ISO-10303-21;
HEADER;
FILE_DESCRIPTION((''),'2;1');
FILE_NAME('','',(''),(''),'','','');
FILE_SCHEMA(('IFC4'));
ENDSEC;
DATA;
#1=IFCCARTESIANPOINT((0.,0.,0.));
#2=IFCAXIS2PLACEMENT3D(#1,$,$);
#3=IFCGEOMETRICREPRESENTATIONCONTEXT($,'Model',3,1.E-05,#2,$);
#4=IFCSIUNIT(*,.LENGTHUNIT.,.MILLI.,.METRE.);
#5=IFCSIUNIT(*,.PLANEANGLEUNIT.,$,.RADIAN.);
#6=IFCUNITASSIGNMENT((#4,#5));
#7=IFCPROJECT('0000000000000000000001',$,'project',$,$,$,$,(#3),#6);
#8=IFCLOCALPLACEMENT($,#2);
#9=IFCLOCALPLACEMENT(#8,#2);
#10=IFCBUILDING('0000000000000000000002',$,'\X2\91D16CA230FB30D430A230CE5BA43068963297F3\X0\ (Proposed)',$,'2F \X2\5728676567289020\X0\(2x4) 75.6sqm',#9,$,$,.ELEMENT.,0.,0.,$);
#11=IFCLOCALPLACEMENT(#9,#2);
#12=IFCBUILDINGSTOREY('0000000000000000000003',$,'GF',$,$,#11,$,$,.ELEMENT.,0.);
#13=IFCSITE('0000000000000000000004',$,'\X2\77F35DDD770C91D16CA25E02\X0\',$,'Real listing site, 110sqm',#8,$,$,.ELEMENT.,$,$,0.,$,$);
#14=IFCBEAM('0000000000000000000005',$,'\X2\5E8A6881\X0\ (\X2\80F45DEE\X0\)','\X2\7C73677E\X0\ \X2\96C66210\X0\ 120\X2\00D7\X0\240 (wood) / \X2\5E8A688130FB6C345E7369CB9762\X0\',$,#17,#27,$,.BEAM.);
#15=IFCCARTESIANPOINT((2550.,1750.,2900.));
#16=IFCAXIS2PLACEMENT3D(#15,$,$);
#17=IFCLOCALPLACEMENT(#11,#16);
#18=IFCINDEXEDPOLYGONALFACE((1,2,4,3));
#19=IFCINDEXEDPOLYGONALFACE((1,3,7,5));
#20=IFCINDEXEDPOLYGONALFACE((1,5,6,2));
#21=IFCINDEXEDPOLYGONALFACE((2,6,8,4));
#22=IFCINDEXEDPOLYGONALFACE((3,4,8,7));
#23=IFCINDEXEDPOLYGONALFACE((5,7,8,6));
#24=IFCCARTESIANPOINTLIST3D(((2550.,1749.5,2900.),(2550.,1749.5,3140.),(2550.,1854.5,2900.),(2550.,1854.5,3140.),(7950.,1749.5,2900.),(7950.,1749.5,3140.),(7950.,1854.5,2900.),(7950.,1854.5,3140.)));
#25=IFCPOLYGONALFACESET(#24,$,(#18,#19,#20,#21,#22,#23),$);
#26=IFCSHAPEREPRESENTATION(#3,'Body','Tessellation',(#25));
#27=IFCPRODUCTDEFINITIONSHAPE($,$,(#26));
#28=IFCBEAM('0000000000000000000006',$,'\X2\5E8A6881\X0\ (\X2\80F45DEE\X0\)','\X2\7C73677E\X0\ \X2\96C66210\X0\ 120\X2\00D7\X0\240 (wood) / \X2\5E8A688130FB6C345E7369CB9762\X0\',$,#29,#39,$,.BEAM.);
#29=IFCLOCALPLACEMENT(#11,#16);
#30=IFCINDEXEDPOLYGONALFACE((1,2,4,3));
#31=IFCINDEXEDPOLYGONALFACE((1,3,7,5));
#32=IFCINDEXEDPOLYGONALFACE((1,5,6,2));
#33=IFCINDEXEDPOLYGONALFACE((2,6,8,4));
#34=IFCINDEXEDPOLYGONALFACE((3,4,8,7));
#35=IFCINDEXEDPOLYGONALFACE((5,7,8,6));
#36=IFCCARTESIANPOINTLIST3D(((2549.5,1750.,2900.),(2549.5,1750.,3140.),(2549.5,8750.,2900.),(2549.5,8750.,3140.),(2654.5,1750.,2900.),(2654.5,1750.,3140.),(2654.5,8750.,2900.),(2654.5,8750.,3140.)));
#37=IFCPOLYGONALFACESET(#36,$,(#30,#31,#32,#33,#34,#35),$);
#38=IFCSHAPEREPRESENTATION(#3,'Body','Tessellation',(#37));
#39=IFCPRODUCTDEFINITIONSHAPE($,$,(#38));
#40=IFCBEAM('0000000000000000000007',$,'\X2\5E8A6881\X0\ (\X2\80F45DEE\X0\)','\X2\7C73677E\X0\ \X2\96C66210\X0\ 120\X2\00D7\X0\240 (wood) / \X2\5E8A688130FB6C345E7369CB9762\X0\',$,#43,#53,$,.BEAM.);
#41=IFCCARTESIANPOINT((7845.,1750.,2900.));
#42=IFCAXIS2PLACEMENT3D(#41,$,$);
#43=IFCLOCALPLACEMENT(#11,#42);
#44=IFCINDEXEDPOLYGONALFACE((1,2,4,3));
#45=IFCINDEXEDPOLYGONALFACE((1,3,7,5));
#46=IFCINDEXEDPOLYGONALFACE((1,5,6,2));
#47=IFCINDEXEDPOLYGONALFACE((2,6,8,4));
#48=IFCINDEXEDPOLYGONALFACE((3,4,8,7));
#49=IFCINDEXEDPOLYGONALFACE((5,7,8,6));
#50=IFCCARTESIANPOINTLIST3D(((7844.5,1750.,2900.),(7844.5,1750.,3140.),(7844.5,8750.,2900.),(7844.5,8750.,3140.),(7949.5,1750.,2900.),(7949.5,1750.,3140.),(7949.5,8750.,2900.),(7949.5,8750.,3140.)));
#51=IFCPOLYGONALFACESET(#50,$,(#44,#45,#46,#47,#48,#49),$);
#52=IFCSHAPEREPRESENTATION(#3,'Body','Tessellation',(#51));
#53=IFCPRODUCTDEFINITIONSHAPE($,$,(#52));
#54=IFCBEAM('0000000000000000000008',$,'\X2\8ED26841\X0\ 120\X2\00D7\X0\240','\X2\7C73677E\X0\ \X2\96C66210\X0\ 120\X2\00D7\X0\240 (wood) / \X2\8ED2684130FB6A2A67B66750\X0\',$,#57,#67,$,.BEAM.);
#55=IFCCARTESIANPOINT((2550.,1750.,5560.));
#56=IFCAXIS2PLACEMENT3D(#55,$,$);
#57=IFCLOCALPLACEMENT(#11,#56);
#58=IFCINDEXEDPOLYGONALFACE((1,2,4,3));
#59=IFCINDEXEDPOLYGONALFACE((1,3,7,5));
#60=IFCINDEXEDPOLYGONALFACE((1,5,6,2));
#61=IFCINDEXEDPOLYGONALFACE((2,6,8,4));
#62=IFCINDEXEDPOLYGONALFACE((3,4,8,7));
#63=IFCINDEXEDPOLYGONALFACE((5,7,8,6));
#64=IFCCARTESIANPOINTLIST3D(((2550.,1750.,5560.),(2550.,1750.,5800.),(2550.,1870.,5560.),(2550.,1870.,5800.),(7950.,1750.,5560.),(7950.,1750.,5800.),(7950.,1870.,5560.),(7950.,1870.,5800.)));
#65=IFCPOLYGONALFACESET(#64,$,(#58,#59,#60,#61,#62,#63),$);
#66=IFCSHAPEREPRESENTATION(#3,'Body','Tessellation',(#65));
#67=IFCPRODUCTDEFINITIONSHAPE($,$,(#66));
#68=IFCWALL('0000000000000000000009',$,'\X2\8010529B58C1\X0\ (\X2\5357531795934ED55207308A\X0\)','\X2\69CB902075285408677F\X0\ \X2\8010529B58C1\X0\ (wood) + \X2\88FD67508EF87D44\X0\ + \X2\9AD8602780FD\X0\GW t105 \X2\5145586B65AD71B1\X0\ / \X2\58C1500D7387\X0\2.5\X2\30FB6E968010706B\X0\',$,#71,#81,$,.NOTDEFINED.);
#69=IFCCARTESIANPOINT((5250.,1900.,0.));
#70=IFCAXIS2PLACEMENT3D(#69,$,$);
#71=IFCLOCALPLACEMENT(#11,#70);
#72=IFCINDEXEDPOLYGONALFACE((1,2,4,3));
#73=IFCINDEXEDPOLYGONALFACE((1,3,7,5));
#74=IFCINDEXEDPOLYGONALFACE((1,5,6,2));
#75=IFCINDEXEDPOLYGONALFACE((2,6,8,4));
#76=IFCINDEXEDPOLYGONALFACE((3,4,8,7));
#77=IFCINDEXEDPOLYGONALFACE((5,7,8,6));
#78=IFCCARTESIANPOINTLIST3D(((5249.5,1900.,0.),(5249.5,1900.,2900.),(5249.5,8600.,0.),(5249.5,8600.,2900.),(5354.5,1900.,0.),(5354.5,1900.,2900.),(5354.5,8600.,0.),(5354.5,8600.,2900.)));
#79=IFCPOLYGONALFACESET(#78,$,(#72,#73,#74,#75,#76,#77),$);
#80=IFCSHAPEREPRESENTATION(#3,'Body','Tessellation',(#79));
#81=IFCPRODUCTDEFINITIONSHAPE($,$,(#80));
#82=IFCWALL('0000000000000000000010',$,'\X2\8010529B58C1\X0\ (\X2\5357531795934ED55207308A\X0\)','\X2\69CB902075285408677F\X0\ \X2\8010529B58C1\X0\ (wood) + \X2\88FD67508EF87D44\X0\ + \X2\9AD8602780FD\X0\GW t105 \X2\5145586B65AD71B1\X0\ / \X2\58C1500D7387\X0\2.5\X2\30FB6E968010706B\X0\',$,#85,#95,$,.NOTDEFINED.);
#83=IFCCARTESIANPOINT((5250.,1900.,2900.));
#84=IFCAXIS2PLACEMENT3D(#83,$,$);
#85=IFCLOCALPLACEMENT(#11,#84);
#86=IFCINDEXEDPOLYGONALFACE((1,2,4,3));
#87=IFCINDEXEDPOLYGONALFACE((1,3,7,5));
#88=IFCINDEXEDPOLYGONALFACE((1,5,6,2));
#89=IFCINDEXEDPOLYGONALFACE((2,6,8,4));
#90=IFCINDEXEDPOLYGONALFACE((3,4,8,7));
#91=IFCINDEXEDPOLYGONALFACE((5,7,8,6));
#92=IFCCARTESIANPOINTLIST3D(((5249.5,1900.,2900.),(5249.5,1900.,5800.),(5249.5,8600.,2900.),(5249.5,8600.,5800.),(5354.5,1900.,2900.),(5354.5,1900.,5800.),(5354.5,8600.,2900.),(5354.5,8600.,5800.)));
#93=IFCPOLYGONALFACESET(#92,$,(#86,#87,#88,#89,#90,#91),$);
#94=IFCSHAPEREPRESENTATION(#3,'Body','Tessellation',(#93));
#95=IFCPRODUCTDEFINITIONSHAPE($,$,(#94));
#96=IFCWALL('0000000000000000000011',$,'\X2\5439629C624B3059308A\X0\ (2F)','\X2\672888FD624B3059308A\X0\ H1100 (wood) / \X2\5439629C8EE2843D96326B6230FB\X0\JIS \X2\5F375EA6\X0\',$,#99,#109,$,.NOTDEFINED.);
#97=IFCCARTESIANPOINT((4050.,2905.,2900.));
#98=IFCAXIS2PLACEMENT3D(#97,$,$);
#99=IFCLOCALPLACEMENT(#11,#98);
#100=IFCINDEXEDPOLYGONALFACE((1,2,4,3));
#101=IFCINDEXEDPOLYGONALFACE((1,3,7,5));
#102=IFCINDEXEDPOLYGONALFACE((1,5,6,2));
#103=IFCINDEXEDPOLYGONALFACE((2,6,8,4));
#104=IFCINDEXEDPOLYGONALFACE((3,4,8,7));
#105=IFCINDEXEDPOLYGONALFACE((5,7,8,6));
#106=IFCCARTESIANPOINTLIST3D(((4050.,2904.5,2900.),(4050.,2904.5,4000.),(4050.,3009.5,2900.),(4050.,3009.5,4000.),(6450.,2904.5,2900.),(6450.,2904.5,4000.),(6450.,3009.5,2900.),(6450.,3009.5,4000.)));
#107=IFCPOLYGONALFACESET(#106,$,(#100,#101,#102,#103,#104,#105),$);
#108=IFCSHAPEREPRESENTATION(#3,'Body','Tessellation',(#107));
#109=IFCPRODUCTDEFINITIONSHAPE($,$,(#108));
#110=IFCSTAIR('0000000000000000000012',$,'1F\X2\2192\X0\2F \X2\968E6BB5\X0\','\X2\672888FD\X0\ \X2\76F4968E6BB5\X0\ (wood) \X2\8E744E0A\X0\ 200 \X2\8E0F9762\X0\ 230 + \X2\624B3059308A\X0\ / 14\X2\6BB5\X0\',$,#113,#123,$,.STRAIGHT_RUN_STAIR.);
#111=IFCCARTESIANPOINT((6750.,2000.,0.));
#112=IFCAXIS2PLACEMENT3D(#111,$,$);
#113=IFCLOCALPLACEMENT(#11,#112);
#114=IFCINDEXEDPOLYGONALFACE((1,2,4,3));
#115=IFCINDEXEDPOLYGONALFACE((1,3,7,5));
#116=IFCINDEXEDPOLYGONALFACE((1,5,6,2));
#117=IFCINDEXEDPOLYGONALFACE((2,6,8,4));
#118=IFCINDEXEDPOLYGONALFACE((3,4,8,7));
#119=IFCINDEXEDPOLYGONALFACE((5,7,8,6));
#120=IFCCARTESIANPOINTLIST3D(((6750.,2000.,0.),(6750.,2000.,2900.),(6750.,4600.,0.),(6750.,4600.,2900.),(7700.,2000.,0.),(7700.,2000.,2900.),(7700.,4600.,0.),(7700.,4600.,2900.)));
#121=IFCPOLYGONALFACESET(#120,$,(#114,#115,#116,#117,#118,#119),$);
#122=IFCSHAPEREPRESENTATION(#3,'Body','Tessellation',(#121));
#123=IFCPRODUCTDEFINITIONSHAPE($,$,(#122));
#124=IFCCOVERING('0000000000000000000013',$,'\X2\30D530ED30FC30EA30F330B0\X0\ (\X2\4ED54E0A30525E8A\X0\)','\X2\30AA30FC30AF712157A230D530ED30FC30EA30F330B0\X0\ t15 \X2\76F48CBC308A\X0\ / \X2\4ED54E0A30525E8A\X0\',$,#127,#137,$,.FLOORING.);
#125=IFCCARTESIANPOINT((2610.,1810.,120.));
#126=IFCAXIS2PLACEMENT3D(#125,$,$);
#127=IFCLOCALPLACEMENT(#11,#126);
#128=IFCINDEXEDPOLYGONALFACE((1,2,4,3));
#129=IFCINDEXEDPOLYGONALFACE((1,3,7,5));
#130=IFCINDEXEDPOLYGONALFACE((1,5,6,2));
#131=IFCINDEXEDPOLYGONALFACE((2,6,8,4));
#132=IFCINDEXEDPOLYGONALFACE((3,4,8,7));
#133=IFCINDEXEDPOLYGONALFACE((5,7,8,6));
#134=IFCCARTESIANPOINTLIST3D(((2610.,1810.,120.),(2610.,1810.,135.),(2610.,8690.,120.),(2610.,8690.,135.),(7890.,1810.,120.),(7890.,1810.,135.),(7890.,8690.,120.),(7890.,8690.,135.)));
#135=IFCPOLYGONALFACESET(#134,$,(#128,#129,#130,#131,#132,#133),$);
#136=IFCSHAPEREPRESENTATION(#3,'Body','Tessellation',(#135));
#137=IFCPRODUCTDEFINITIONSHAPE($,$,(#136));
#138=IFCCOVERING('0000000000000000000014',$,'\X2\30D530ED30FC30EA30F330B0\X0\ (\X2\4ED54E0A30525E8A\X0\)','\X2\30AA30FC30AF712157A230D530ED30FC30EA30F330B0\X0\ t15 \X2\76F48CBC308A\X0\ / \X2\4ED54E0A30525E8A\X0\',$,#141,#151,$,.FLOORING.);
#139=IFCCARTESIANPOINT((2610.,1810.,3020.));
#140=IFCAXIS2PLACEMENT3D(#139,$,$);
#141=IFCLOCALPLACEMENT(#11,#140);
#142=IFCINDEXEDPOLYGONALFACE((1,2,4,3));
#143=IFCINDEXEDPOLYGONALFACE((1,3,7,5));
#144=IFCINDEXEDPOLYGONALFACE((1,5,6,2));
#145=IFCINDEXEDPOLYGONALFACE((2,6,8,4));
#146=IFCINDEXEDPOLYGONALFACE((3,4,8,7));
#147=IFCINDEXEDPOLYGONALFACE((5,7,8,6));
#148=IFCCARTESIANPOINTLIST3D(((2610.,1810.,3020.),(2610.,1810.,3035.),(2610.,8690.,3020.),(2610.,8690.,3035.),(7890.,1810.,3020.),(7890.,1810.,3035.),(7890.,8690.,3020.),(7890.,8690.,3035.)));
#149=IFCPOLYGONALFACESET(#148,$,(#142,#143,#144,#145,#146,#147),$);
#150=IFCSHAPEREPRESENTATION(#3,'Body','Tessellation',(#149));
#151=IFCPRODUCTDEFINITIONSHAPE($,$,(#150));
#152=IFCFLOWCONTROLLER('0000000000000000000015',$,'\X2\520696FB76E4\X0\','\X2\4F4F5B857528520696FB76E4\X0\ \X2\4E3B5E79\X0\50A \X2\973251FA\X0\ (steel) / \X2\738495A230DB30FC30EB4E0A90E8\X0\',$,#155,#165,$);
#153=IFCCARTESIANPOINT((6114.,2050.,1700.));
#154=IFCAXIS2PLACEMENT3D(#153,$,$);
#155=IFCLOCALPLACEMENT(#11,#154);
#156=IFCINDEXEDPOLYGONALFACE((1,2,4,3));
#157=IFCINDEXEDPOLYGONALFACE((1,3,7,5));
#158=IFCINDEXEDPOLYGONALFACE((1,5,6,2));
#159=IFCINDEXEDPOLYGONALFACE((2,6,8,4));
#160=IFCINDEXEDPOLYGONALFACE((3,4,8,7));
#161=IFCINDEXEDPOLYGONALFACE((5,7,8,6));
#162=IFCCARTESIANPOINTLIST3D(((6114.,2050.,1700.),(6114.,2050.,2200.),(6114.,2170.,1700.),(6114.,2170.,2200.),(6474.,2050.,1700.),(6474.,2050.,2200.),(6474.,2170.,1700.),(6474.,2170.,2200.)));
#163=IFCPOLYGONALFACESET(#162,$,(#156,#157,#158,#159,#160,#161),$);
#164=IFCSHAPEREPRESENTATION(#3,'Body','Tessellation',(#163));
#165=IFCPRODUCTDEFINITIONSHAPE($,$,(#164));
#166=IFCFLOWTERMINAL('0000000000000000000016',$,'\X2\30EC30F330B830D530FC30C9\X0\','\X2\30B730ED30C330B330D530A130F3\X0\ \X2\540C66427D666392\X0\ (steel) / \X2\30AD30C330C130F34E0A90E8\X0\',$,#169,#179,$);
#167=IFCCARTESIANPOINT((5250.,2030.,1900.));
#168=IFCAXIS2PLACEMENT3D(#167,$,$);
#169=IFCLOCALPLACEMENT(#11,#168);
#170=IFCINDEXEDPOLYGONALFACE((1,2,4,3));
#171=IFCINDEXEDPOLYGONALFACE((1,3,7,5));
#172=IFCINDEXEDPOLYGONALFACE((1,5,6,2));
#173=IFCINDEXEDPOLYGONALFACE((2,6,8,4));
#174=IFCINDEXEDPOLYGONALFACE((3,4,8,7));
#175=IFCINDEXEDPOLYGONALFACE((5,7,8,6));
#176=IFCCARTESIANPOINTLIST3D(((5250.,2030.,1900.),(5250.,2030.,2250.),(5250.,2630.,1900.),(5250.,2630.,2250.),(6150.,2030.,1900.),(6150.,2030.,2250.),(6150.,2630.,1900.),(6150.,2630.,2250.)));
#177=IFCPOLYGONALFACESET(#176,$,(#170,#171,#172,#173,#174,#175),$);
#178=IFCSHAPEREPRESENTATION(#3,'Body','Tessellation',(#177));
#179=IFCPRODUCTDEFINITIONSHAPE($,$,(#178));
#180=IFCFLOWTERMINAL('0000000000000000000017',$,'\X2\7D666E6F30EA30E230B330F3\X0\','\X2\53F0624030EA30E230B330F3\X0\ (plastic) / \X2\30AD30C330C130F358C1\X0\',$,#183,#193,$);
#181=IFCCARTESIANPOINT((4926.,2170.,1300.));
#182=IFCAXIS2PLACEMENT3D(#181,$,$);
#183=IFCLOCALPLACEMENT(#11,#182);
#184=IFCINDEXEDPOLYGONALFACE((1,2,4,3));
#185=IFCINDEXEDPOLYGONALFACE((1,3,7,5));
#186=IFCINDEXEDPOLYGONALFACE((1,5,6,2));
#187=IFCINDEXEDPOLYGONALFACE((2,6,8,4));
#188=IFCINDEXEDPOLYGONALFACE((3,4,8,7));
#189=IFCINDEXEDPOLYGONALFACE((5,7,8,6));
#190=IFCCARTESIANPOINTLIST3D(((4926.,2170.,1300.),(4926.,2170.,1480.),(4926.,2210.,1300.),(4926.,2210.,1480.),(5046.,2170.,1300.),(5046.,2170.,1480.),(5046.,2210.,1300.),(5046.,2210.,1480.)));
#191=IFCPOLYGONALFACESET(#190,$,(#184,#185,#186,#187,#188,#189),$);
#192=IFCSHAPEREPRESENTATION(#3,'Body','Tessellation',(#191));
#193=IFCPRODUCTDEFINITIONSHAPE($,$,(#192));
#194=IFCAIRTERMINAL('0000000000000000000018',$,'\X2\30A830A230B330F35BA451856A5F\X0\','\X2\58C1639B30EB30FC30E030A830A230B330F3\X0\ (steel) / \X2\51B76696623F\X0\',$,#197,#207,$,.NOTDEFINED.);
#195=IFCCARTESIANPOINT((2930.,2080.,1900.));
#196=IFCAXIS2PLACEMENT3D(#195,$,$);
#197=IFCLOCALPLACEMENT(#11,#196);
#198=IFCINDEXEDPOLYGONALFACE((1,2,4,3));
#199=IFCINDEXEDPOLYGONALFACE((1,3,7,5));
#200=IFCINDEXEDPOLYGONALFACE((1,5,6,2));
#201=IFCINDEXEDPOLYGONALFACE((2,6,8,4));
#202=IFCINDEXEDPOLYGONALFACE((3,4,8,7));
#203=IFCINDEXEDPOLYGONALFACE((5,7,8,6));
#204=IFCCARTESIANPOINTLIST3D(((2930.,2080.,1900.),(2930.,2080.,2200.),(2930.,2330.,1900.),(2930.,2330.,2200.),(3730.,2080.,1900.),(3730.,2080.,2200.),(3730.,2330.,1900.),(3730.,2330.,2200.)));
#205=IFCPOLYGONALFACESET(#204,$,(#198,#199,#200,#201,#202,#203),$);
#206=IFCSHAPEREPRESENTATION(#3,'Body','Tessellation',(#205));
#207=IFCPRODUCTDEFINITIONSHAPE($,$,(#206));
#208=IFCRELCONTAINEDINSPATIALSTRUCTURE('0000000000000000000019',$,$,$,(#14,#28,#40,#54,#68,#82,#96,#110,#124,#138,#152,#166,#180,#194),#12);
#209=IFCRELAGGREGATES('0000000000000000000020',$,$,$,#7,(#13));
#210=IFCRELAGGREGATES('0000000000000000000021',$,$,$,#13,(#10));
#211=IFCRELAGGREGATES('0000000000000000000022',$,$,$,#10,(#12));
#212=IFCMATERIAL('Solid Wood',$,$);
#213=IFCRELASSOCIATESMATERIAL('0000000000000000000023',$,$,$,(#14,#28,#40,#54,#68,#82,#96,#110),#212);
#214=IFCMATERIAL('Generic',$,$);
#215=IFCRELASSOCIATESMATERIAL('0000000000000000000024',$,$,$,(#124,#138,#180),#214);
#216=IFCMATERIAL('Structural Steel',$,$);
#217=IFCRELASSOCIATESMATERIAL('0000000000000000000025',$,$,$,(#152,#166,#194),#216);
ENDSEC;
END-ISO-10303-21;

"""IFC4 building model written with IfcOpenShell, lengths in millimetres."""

from ifc_helpers import new_model, si_unit, frame, frame_2d, origin, place, context, project, spatial, rectangle, extrude, material, element, save


model = new_model("IFC4")

# Units and contexts
model_context = context("Model", 3, precision=1e-05, world=origin())
ifc_project = project(units=[si_unit("LENGTHUNIT", "METRE", prefix="MILLI"), si_unit("PLANEANGLEUNIT", "RADIAN")], contexts=[model_context])

# Site, building, storey
site_placement = place(None, origin())
site = spatial("IfcSite", under=ifc_project, at=site_placement, Name="石川県金沢市", ObjectType="Real listing site, 110sqm", CompositionType="ELEMENT", RefElevation=0.0)
building_placement = place(site_placement, origin())
building = spatial("IfcBuilding", under=site, at=building_placement, Name="金沢・ピアノ室と防音 (Proposed)", ObjectType="2F 在来木造(2x4) 75.6sqm", CompositionType="ELEMENT", ElevationOfRefHeight=0.0, ElevationOfTerrain=0.0)
storey_placement = place(building_placement, origin())
storey = spatial("IfcBuildingStorey", under=building, at=storey_placement, Name="GF", CompositionType="ELEMENT", Elevation=0.0)

# Shared definitions
ifc_material_1 = material(Name="Solid Wood")

# Beams
beam_1_placement = place(storey_placement, frame((2550.0, 1750.0, 2900.0)))
element("IfcBeam", 1, at=beam_1_placement, inside=storey, material=ifc_material_1, Name="床梁 (胴差)", Description="米松 集成 120×240 (wood) / 床梁・水平構面", PredefinedType="BEAM", context=model_context, shape_type="SweptSolid", body=[
    extrude(rectangle(XDim=5400.0, YDim=105.0, at=frame_2d((2700.0, 52.0))), frame((2550.0, 1750.0, 2900.0)), (0.0, 0.0, 1.0), 240.0),
])
beam_2_placement = place(storey_placement, frame((2550.0, 1750.0, 2900.0)))
element("IfcBeam", 2, at=beam_2_placement, inside=storey, material=ifc_material_1, Name="床梁 (胴差)", Description="米松 集成 120×240 (wood) / 床梁・水平構面", PredefinedType="BEAM", context=model_context, shape_type="SweptSolid", body=[
    extrude(rectangle(XDim=105.0, YDim=7000.0, at=frame_2d((52.0, 3500.0))), frame((2550.0, 1750.0, 2900.0)), (0.0, 0.0, 1.0), 240.0),
])
beam_3_placement = place(storey_placement, frame((7845.0, 1750.0, 2900.0)))
element("IfcBeam", 3, at=beam_3_placement, inside=storey, material=ifc_material_1, Name="床梁 (胴差)", Description="米松 集成 120×240 (wood) / 床梁・水平構面", PredefinedType="BEAM", context=model_context, shape_type="SweptSolid", body=[
    extrude(rectangle(XDim=105.0, YDim=7000.0, at=frame_2d((52.0, 3500.0))), frame((7845.0, 1750.0, 2900.0)), (0.0, 0.0, 1.0), 240.0),
])
beam_4_placement = place(storey_placement, frame((2550.0, 1750.0, 5560.0)))
element("IfcBeam", 4, at=beam_4_placement, inside=storey, material=ifc_material_1, Name="軒桁 120×240", Description="米松 集成 120×240 (wood) / 軒桁・横架材", PredefinedType="BEAM", context=model_context, shape_type="SweptSolid", body=[
    extrude(rectangle(XDim=5400.0, YDim=120.0, at=frame_2d((2700.0, 60.0))), frame((2550.0, 1750.0, 5560.0)), (0.0, 0.0, 1.0), 240.0),
])

# Walls
wall_1_placement = place(storey_placement, frame((5250.0, 1900.0, 0.0)))
element("IfcWall", 5, at=wall_1_placement, inside=storey, material=ifc_material_1, Name="耐力壁 (南北間仕切り)", Description="構造用合板 耐力壁 (wood) + 製材軸組 + 高性能GW t105 充填断熱 / 壁倍率2.5・準耐火", PredefinedType="NOTDEFINED", context=model_context, shape_type="SweptSolid", body=[
    extrude(rectangle(XDim=105.0, YDim=6700.0, at=frame_2d((52.0, 3350.0))), frame((5250.0, 1900.0, 0.0)), (0.0, 0.0, 1.0), 2900.0),
])
wall_2_placement = place(storey_placement, frame((5250.0, 1900.0, 2900.0)))
element("IfcWall", 6, at=wall_2_placement, inside=storey, material=ifc_material_1, Name="耐力壁 (南北間仕切り)", Description="構造用合板 耐力壁 (wood) + 製材軸組 + 高性能GW t105 充填断熱 / 壁倍率2.5・準耐火", PredefinedType="NOTDEFINED", context=model_context, shape_type="SweptSolid", body=[
    extrude(rectangle(XDim=105.0, YDim=6700.0, at=frame_2d((52.0, 3350.0))), frame((5250.0, 1900.0, 2900.0)), (0.0, 0.0, 1.0), 2900.0),
])
wall_3_placement = place(storey_placement, frame((4050.0, 2905.0, 2900.0)))
element("IfcWall", 7, at=wall_3_placement, inside=storey, material=ifc_material_1, Name="吹抜手すり (2F)", Description="木製手すり H1100 (wood) / 吹抜転落防止・JIS 強度", PredefinedType="NOTDEFINED", context=model_context, shape_type="SweptSolid", body=[
    extrude(rectangle(XDim=2400.0, YDim=105.0, at=frame_2d((1200.0, 52.0))), frame((4050.0, 2905.0, 2900.0)), (0.0, 0.0, 1.0), 1100.0),
])

# Stair
stair_placement = place(storey_placement, frame((6750.0, 2000.0, 0.0)))
element("IfcStair", 8, at=stair_placement, inside=storey, material=ifc_material_1, Name="1F→2F 階段", Description="木製 直階段 (wood) 蹴上 200 踏面 230 + 手すり / 14段", PredefinedType="STRAIGHT_RUN_STAIR", context=model_context, shape_type="SweptSolid", body=[
    extrude(rectangle(XDim=950.0, YDim=2600.0, at=frame_2d((475.0, 1300.0))), frame((6750.0, 2000.0, 0.0)), (0.0, 0.0, 1.0), 2900.0),
])

# Coverings
ifc_material_2 = material(Name="Generic")
covering_1_placement = place(storey_placement, frame((2610.0, 1810.0, 120.0)))
element("IfcCovering", 9, at=covering_1_placement, inside=storey, material=ifc_material_2, Name="フローリング (仕上げ床)", Description="オーク無垢フローリング t15 直貼り / 仕上げ床", PredefinedType="FLOORING", context=model_context, shape_type="SweptSolid", body=[
    extrude(rectangle(XDim=5280.0, YDim=6880.0, at=frame_2d((2640.0, 3440.0))), frame((2610.0, 1810.0, 120.0)), (0.0, 0.0, 1.0), 15.0),
])
covering_2_placement = place(storey_placement, frame((2610.0, 1810.0, 3020.0)))
element("IfcCovering", 10, at=covering_2_placement, inside=storey, material=ifc_material_2, Name="フローリング (仕上げ床)", Description="オーク無垢フローリング t15 直貼り / 仕上げ床", PredefinedType="FLOORING", context=model_context, shape_type="SweptSolid", body=[
    extrude(rectangle(XDim=5280.0, YDim=6880.0, at=frame_2d((2640.0, 3440.0))), frame((2610.0, 1810.0, 3020.0)), (0.0, 0.0, 1.0), 15.0),
])

# Flow controller
ifc_material_3 = material(Name="Structural Steel")
flow_controller_placement = place(storey_placement, frame((6114.0, 2050.0, 1700.0)))
element("IfcFlowController", 11, at=flow_controller_placement, inside=storey, material=ifc_material_3, Name="分電盤", Description="住宅用分電盤 主幹50A 露出 (steel) / 玄関ホール上部", context=model_context, shape_type="SweptSolid", body=[
    extrude(rectangle(XDim=360.0, YDim=120.0, at=frame_2d((180.0, 60.0))), frame((6114.0, 2050.0, 1700.0)), (0.0, 0.0, 1.0), 500.0),
])

# Flow terminals
flow_terminal_1_placement = place(storey_placement, frame((5250.0, 2030.0, 1900.0)))
element("IfcFlowTerminal", 12, at=flow_terminal_1_placement, inside=storey, material=ifc_material_3, Name="レンジフード", Description="シロッコファン 同時給排 (steel) / キッチン上部", context=model_context, shape_type="SweptSolid", body=[
    extrude(rectangle(XDim=900.0, YDim=600.0, at=frame_2d((450.0, 300.0))), frame((5250.0, 2030.0, 1900.0)), (0.0, 0.0, 1.0), 350.0),
])
flow_terminal_2_placement = place(storey_placement, frame((4926.0, 2170.0, 1300.0)))
element("IfcFlowTerminal", 13, at=flow_terminal_2_placement, inside=storey, material=ifc_material_2, Name="給湯リモコン", Description="台所リモコン (plastic) / キッチン壁", context=model_context, shape_type="SweptSolid", body=[
    extrude(rectangle(XDim=120.0, YDim=40.0, at=frame_2d((60.0, 20.0))), frame((4926.0, 2170.0, 1300.0)), (0.0, 0.0, 1.0), 180.0),
])

# Air terminal
air_terminal_1_placement = place(storey_placement, frame((2930.0, 2080.0, 1900.0)))
element("IfcAirTerminal", 14, at=air_terminal_1_placement, inside=storey, material=ifc_material_3, Name="エアコン室内機", Description="壁掛ルームエアコン (steel) / 冷暖房", PredefinedType="NOTDEFINED", context=model_context, shape_type="SweptSolid", body=[
    extrude(rectangle(XDim=800.0, YDim=250.0, at=frame_2d((400.0, 125.0))), frame((2930.0, 2080.0, 1900.0)), (0.0, 0.0, 1.0), 300.0),
])

save(model, "model.ifc")
